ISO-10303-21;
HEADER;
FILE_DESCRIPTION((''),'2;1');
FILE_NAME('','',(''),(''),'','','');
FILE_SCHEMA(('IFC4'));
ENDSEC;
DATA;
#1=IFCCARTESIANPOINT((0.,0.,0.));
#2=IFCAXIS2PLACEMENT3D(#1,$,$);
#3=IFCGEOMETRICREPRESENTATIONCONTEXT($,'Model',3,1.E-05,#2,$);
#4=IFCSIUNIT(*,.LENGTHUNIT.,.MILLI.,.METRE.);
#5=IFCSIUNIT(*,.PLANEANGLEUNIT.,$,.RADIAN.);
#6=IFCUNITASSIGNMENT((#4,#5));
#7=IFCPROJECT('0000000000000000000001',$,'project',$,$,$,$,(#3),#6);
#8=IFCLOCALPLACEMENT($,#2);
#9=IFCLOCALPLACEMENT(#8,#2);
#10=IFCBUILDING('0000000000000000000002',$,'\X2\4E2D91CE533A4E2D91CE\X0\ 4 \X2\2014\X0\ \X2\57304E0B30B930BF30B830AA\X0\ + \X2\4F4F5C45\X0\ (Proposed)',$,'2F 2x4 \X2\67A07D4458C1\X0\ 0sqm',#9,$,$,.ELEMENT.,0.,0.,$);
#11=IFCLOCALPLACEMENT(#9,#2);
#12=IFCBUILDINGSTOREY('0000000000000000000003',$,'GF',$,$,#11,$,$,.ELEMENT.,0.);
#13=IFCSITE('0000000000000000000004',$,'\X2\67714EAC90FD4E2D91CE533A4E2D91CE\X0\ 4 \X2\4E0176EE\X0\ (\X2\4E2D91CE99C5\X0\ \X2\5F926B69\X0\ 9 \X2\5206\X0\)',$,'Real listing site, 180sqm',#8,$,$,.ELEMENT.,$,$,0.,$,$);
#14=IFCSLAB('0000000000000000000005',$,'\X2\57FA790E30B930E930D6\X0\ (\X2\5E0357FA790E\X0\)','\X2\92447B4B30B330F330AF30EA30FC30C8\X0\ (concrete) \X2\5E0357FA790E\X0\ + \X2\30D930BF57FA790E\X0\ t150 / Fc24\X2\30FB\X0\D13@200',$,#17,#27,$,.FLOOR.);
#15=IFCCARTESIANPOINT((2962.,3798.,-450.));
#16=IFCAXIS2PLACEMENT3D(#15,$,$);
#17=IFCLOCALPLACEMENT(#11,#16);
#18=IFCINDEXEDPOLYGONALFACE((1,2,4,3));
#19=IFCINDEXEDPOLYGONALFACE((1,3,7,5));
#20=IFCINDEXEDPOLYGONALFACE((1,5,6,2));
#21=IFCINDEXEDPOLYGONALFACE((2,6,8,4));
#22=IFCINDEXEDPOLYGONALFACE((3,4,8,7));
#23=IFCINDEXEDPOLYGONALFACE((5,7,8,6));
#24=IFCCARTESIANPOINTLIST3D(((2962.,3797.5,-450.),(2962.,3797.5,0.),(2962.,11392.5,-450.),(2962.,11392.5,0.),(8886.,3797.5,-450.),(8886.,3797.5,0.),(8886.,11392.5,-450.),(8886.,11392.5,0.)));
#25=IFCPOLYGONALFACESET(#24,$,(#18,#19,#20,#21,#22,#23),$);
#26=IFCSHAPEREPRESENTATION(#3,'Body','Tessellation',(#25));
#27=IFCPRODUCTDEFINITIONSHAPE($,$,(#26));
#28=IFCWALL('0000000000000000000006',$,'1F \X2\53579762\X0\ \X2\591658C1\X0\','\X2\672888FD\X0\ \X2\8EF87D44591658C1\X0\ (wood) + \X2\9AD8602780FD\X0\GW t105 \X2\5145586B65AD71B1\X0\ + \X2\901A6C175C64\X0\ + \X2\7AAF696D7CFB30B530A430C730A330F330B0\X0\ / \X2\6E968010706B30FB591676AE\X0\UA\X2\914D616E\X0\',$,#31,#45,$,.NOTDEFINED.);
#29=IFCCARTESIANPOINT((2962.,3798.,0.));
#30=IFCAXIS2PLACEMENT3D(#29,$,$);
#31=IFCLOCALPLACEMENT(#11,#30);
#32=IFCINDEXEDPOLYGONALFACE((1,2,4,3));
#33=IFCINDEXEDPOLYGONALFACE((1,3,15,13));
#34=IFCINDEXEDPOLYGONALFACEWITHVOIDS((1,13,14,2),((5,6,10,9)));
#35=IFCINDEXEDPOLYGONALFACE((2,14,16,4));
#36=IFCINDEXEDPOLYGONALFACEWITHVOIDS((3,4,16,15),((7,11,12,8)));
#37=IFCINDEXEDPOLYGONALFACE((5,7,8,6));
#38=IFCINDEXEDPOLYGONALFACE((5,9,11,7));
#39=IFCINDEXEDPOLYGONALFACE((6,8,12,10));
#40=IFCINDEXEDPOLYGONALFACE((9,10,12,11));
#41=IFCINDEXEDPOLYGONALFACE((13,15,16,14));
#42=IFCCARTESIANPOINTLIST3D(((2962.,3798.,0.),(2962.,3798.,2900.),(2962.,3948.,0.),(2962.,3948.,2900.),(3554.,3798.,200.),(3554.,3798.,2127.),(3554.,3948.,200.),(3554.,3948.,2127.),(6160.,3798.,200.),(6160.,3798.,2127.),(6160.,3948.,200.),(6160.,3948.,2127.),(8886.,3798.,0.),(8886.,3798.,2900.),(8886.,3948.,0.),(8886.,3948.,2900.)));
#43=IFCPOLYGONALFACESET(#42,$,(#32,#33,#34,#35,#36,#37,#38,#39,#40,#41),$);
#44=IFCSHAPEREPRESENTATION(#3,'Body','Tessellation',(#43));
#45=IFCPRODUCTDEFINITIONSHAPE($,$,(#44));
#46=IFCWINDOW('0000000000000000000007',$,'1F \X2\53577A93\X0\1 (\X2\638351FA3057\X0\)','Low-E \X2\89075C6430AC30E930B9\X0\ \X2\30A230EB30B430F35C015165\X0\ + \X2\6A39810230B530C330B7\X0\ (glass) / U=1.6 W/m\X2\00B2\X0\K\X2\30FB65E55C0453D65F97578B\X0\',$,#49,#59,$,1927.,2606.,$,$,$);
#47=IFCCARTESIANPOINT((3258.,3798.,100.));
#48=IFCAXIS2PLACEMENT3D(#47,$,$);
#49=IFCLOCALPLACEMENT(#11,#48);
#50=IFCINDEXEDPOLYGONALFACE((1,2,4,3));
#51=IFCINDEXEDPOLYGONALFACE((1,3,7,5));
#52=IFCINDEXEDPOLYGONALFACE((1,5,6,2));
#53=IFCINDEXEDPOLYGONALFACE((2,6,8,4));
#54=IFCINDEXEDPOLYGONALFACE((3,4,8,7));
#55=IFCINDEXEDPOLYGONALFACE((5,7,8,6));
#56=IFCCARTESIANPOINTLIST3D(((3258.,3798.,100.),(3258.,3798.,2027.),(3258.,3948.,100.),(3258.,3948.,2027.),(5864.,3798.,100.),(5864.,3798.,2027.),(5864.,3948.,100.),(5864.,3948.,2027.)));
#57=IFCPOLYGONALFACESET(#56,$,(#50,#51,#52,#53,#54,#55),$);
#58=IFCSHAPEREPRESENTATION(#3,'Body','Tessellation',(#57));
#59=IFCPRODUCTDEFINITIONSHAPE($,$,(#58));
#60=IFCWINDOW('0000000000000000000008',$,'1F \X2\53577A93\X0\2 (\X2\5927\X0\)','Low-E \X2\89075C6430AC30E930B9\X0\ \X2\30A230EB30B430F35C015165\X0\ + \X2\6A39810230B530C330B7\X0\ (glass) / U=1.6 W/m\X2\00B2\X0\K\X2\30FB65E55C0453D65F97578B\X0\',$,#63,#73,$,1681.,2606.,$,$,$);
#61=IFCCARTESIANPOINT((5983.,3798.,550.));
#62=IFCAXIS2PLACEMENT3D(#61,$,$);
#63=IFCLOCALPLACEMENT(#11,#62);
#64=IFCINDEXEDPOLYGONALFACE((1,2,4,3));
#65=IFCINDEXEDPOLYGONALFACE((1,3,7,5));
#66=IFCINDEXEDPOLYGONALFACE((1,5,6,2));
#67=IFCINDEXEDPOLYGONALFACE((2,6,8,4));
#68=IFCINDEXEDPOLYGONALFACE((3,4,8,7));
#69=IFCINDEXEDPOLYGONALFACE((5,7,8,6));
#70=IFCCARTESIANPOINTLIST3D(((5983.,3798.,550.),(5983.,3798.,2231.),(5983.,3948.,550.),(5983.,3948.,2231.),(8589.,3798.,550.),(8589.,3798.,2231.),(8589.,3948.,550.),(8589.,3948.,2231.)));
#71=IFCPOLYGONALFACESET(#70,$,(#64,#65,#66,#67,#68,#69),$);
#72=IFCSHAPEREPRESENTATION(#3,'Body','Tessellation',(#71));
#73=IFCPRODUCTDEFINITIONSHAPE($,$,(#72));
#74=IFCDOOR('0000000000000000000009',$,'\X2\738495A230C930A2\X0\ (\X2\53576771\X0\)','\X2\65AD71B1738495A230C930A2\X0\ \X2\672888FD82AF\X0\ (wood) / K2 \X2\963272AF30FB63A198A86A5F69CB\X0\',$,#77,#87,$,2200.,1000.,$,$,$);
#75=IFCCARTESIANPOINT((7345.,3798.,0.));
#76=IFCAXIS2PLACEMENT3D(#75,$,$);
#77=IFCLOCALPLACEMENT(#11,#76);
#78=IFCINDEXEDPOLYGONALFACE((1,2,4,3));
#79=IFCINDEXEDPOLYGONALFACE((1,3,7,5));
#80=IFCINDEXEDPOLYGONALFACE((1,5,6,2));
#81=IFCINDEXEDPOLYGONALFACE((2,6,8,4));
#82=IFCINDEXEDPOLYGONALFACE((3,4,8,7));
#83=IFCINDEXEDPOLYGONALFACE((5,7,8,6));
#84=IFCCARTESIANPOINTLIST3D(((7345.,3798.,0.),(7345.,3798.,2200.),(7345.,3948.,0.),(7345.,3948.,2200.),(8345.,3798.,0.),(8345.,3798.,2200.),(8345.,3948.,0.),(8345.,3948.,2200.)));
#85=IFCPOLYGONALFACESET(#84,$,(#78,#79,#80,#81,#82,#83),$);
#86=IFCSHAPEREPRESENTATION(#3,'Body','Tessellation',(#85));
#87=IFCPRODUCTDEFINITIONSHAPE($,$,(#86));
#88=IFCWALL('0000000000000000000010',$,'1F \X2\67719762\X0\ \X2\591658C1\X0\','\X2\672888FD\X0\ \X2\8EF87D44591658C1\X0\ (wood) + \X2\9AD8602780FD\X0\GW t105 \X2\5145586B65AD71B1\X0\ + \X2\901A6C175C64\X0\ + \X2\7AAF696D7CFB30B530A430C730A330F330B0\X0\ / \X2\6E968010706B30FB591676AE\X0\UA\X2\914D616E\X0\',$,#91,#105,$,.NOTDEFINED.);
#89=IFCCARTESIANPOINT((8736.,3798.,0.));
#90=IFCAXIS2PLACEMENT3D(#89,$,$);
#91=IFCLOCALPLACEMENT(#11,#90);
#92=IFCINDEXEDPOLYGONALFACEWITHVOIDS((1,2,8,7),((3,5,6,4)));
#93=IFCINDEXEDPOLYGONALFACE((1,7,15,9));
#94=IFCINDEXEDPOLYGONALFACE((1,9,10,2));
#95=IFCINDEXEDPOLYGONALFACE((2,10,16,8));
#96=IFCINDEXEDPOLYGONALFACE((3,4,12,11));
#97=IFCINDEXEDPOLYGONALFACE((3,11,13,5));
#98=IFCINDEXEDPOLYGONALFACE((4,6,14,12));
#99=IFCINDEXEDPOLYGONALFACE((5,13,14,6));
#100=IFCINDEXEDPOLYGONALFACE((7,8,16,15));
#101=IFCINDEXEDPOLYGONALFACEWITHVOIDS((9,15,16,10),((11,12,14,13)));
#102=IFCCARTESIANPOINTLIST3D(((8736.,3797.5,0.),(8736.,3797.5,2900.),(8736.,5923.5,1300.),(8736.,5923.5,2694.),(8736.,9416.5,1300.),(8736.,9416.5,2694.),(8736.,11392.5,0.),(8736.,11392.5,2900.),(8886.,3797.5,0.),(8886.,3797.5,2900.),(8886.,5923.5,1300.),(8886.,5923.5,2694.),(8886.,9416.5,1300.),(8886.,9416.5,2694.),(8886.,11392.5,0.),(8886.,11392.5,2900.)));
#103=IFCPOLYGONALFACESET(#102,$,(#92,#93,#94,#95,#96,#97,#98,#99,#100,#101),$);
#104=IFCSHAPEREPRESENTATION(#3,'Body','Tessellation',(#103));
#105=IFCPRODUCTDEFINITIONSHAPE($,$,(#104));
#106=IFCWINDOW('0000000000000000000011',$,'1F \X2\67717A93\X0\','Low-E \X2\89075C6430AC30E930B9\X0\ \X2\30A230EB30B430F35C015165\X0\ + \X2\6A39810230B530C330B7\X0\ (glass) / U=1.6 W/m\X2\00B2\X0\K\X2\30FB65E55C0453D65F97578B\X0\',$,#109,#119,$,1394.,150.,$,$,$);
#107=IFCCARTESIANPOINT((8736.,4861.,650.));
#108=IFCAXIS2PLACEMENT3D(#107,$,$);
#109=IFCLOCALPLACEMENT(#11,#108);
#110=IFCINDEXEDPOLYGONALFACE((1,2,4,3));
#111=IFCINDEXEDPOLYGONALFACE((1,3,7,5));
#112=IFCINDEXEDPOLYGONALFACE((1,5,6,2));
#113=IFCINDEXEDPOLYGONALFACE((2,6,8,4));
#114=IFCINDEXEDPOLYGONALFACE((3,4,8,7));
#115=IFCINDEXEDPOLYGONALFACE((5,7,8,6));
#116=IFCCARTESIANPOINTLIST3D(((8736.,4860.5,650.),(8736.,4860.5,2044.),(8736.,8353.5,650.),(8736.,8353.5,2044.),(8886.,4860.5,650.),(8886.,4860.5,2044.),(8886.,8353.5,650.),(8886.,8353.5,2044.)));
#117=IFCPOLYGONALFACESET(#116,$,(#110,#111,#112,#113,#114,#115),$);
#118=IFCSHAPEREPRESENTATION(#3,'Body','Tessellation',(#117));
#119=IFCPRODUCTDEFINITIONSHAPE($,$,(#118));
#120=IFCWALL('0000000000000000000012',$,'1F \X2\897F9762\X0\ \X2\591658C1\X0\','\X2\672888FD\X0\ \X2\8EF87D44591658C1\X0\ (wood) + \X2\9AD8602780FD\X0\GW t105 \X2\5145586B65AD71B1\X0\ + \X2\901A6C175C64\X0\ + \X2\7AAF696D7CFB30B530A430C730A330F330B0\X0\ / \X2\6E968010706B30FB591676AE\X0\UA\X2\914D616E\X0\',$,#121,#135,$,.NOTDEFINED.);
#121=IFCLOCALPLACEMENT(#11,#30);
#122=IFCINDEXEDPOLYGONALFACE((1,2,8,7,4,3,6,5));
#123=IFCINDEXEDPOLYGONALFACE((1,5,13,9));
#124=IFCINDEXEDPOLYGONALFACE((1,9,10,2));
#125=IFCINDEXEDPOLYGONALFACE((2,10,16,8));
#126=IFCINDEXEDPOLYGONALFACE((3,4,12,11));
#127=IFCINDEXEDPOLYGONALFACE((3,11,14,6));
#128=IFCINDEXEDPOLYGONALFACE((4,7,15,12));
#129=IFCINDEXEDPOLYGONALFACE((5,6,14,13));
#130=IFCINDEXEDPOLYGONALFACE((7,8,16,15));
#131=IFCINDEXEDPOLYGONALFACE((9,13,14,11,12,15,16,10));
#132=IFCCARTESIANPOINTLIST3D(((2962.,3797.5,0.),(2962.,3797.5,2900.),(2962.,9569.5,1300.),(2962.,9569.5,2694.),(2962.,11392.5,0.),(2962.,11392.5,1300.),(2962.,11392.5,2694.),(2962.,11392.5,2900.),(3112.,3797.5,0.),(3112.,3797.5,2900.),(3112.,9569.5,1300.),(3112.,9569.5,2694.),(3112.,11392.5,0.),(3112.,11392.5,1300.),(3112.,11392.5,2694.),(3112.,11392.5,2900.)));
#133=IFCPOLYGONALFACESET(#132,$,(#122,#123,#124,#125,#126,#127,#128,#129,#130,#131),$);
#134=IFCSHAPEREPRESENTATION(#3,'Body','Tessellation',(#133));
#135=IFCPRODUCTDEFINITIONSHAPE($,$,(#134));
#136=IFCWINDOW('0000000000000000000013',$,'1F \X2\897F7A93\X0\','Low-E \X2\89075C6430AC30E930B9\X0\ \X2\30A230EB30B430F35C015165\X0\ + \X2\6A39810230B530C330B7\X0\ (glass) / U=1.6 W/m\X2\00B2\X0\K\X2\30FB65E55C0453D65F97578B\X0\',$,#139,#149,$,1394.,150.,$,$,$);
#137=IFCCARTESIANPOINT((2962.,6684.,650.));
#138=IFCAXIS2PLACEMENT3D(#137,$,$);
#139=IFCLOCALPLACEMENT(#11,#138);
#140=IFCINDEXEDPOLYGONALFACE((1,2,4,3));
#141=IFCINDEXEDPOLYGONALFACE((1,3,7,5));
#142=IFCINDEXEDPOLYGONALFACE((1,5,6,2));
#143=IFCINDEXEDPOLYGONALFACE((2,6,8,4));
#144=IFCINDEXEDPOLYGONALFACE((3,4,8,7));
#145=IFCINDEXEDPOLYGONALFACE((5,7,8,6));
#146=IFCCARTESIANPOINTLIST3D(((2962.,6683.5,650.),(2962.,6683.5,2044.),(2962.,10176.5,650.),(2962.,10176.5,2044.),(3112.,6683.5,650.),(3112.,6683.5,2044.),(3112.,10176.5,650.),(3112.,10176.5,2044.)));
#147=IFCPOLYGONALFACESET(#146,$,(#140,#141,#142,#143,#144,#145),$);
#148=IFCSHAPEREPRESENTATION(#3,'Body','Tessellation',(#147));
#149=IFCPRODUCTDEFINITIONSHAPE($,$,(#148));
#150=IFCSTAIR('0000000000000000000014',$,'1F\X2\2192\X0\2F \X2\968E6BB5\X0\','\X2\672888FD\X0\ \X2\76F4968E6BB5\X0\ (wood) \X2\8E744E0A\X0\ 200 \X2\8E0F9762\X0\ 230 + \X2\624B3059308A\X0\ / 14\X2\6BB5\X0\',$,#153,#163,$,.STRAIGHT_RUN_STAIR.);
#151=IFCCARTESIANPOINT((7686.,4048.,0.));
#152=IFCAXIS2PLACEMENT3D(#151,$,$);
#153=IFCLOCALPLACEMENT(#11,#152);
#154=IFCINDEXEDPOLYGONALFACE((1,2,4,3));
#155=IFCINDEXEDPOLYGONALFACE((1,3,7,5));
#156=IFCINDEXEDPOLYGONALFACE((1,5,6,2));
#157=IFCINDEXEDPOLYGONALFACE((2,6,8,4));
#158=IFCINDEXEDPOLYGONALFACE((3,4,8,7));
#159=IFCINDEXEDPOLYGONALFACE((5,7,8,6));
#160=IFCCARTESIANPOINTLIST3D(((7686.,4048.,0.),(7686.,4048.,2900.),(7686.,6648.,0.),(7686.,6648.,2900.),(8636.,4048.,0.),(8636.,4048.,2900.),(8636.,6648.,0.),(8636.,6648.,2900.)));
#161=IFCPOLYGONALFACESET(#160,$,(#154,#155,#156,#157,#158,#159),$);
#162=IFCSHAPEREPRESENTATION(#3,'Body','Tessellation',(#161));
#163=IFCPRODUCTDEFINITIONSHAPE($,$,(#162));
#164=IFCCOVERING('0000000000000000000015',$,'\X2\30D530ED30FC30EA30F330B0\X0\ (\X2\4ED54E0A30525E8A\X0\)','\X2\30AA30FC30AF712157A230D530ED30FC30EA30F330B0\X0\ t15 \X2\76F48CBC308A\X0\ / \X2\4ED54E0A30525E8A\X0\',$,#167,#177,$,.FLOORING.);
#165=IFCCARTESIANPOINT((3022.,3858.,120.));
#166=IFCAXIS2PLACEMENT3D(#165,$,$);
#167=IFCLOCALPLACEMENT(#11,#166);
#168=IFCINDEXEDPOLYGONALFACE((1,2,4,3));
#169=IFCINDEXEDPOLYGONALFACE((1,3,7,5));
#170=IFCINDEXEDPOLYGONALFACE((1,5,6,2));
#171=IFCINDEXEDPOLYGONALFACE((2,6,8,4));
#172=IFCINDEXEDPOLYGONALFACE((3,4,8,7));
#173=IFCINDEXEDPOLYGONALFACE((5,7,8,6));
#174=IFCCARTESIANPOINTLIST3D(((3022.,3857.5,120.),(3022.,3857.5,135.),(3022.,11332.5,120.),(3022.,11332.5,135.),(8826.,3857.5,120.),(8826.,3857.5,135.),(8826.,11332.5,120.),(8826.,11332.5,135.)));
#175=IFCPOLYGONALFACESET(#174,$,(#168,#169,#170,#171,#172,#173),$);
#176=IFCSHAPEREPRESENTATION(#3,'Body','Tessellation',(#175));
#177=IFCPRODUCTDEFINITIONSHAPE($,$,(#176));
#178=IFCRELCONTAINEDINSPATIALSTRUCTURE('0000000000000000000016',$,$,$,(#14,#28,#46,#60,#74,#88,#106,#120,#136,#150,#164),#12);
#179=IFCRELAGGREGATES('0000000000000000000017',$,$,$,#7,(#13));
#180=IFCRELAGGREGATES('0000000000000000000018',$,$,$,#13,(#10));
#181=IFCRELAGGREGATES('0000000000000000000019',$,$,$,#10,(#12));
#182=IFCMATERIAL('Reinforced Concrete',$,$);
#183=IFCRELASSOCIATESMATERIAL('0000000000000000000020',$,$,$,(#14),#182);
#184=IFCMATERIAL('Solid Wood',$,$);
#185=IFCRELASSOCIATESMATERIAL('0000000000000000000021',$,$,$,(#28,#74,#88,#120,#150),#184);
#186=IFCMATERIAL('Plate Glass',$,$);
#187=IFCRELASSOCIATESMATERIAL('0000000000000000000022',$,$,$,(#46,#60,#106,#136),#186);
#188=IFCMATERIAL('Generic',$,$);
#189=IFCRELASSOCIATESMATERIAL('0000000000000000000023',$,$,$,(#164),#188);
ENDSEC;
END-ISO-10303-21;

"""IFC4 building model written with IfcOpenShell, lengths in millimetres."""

from ifc_helpers import new_model, si_unit, frame, frame_2d, origin, place, context, project, spatial, rectangle, extrude, material, element, fill, save


model = new_model("IFC4")

# Units and contexts
model_context = context("Model", 3, precision=1e-05, world=origin())
ifc_project = project(units=[si_unit("LENGTHUNIT", "METRE", prefix="MILLI"), si_unit("PLANEANGLEUNIT", "RADIAN")], contexts=[model_context])

# Site, building, storey
site_placement = place(None, origin())
site = spatial("IfcSite", under=ifc_project, at=site_placement, Name="東京都中野区中野 4 丁目 (中野駅 徒歩 9 分)", ObjectType="Real listing site, 180sqm", CompositionType="ELEMENT", RefElevation=0.0)
building_placement = place(site_placement, origin())
building = spatial("IfcBuilding", under=site, at=building_placement, Name="中野区中野 4 — 地下スタジオ + 住居 (Proposed)", ObjectType="2F 2x4 枠組壁 0sqm", CompositionType="ELEMENT", ElevationOfRefHeight=0.0, ElevationOfTerrain=0.0)
storey_placement = place(building_placement, origin())
storey = spatial("IfcBuildingStorey", under=building, at=storey_placement, Name="GF", CompositionType="ELEMENT", Elevation=0.0)

# Slab
ifc_material_1 = material(Name="Reinforced Concrete")
slab_1_placement = place(storey_placement, frame((2962.0, 3798.0, -450.0)))
element("IfcSlab", 1, at=slab_1_placement, inside=storey, material=ifc_material_1, Name="基礎スラブ (布基礎)", Description="鉄筋コンクリート (concrete) 布基礎 + ベタ基礎 t150 / Fc24・D13@200", PredefinedType="FLOOR", context=model_context, shape_type="SweptSolid", body=[
    extrude(rectangle(XDim=5924.0, YDim=7595.0, at=frame_2d((2962.0, 3797.0))), frame((2962.0, 3798.0, -450.0)), (0.0, 0.0, 1.0), 450.0),
])
ifc_material_2 = material(Name="Solid Wood")

# Wall, openings, windows, door
wall_1_placement = place(storey_placement, frame((2962.0, 3798.0, 0.0)))
wall_1 = element("IfcWall", 2, at=wall_1_placement, inside=storey, material=ifc_material_2, Name="1F 南面 外壁", Description="木製 軸組外壁 (wood) + 高性能GW t105 充填断熱 + 通気層 + 窯業系サイディング / 準耐火・外皮UA配慮", PredefinedType="NOTDEFINED", context=model_context, shape_type="SweptSolid", body=[
    extrude(rectangle(XDim=5924.0, YDim=150.0, at=frame_2d((2962.0, 75.0))), frame((2962.0, 3798.0, 0.0)), (0.0, 0.0, 1.0), 2900.0),
])
opening_1_placement = place(storey_placement, frame((3258.0, 3798.0, 100.0)))
opening_1 = element("IfcOpeningElement", 3, at=opening_1_placement, cuts=wall_1, PredefinedType="NOTDEFINED", context=model_context, shape_type="SweptSolid", body=[
    extrude(rectangle(XDim=2606.0, YDim=150.0, at=frame_2d((1303.0, 75.0))), frame((3258.0, 3798.0, 100.0)), (0.0, 0.0, 1.0), 1927.0),
])
opening_2_placement = place(storey_placement, frame((5983.0, 3798.0, 550.0)))
opening_2 = element("IfcOpeningElement", 4, at=opening_2_placement, cuts=wall_1, PredefinedType="NOTDEFINED", context=model_context, shape_type="SweptSolid", body=[
    extrude(rectangle(XDim=2606.0, YDim=150.0, at=frame_2d((1303.0, 75.0))), frame((5983.0, 3798.0, 550.0)), (0.0, 0.0, 1.0), 1681.0),
])
opening_3_placement = place(storey_placement, frame((7345.0, 3798.0, 0.0)))
opening_3 = element("IfcOpeningElement", 5, at=opening_3_placement, cuts=wall_1, PredefinedType="NOTDEFINED", context=model_context, shape_type="SweptSolid", body=[
    extrude(rectangle(XDim=1000.0, YDim=150.0, at=frame_2d((500.0, 75.0))), frame((7345.0, 3798.0, 0.0)), (0.0, 0.0, 1.0), 2200.0),
])
ifc_material_3 = material(Name="Plate Glass")
window_1_placement = place(storey_placement, frame((3258.0, 3798.0, 100.0)))
window_1 = element("IfcWindow", 6, at=window_1_placement, inside=storey, material=ifc_material_3, Name="1F 南窓1 (掃出し)", Description="Low-E 複層ガラス アルゴン封入 + 樹脂サッシ (glass) / U=1.6 W/m²K・日射取得型", OverallHeight=1927.0, OverallWidth=2606.0, context=model_context, shape_type="SweptSolid", body=[
    extrude(rectangle(XDim=2606.0, YDim=150.0, at=frame_2d((1303.0, 75.0))), frame((3258.0, 3798.0, 100.0)), (0.0, 0.0, 1.0), 1927.0),
])
fill(opening_1, window_1)
window_2_placement = place(storey_placement, frame((5983.0, 3798.0, 550.0)))
window_2 = element("IfcWindow", 7, at=window_2_placement, inside=storey, material=ifc_material_3, Name="1F 南窓2 (大)", Description="Low-E 複層ガラス アルゴン封入 + 樹脂サッシ (glass) / U=1.6 W/m²K・日射取得型", OverallHeight=1681.0, OverallWidth=2606.0, context=model_context, shape_type="SweptSolid", body=[
    extrude(rectangle(XDim=2606.0, YDim=150.0, at=frame_2d((1303.0, 75.0))), frame((5983.0, 3798.0, 550.0)), (0.0, 0.0, 1.0), 1681.0),
])
fill(opening_2, window_2)
door_placement = place(storey_placement, frame((7345.0, 3798.0, 0.0)))
door = element("IfcDoor", 8, at=door_placement, inside=storey, material=ifc_material_2, Name="玄関ドア (南東)", Description="断熱玄関ドア 木製芯 (wood) / K2 防犯・採風機構", OverallHeight=2200.0, OverallWidth=1000.0, context=model_context, shape_type="SweptSolid", body=[
    extrude(rectangle(XDim=1000.0, YDim=150.0, at=frame_2d((500.0, 75.0))), frame((7345.0, 3798.0, 0.0)), (0.0, 0.0, 1.0), 2200.0),
])
fill(opening_3, door)

# Walls, openings, windows
wall_2_placement = place(storey_placement, frame((8736.0, 3798.0, 0.0)))
wall_2 = element("IfcWall", 9, at=wall_2_placement, inside=storey, material=ifc_material_2, Name="1F 東面 外壁", Description="木製 軸組外壁 (wood) + 高性能GW t105 充填断熱 + 通気層 + 窯業系サイディング / 準耐火・外皮UA配慮", PredefinedType="NOTDEFINED", context=model_context, shape_type="SweptSolid", body=[
    extrude(rectangle(XDim=150.0, YDim=7595.0, at=frame_2d((75.0, 3797.0))), frame((8736.0, 3798.0, 0.0)), (0.0, 0.0, 1.0), 2900.0),
])
opening_4_placement = place(storey_placement, frame((8736.0, 4861.0, 650.0)))
opening_4 = element("IfcOpeningElement", 10, at=opening_4_placement, cuts=wall_2, PredefinedType="NOTDEFINED", context=model_context, shape_type="SweptSolid", body=[
    extrude(rectangle(XDim=150.0, YDim=3493.0, at=frame_2d((75.0, 1746.0))), frame((8736.0, 4861.0, 650.0)), (0.0, 0.0, 1.0), 1394.0),
])
window_3_placement = place(storey_placement, frame((8736.0, 4861.0, 650.0)))
window_3 = element("IfcWindow", 11, at=window_3_placement, inside=storey, material=ifc_material_3, Name="1F 東窓", Description="Low-E 複層ガラス アルゴン封入 + 樹脂サッシ (glass) / U=1.6 W/m²K・日射取得型", OverallHeight=1394.0, OverallWidth=150.0, context=model_context, shape_type="SweptSolid", body=[
    extrude(rectangle(XDim=150.0, YDim=3493.0, at=frame_2d((75.0, 1746.0))), frame((8736.0, 4861.0, 650.0)), (0.0, 0.0, 1.0), 1394.0),
])
fill(opening_4, window_3)
wall_3_placement = place(storey_placement, frame((2962.0, 3798.0, 0.0)))
wall_3 = element("IfcWall", 12, at=wall_3_placement, inside=storey, material=ifc_material_2, Name="1F 西面 外壁", Description="木製 軸組外壁 (wood) + 高性能GW t105 充填断熱 + 通気層 + 窯業系サイディング / 準耐火・外皮UA配慮", PredefinedType="NOTDEFINED", context=model_context, shape_type="SweptSolid", body=[
    extrude(rectangle(XDim=150.0, YDim=7595.0, at=frame_2d((75.0, 3797.0))), frame((2962.0, 3798.0, 0.0)), (0.0, 0.0, 1.0), 2900.0),
])
opening_5_placement = place(storey_placement, frame((2962.0, 6684.0, 650.0)))
opening_5 = element("IfcOpeningElement", 13, at=opening_5_placement, cuts=wall_3, PredefinedType="NOTDEFINED", context=model_context, shape_type="SweptSolid", body=[
    extrude(rectangle(XDim=150.0, YDim=3493.0, at=frame_2d((75.0, 1746.0))), frame((2962.0, 6684.0, 650.0)), (0.0, 0.0, 1.0), 1394.0),
])
window_4_placement = place(storey_placement, frame((2962.0, 6684.0, 650.0)))
window_4 = element("IfcWindow", 14, at=window_4_placement, inside=storey, material=ifc_material_3, Name="1F 西窓", Description="Low-E 複層ガラス アルゴン封入 + 樹脂サッシ (glass) / U=1.6 W/m²K・日射取得型", OverallHeight=1394.0, OverallWidth=150.0, context=model_context, shape_type="SweptSolid", body=[
    extrude(rectangle(XDim=150.0, YDim=3493.0, at=frame_2d((75.0, 1746.0))), frame((2962.0, 6684.0, 650.0)), (0.0, 0.0, 1.0), 1394.0),
])
fill(opening_5, window_4)

# Stair
stair_placement = place(storey_placement, frame((7686.0, 4048.0, 0.0)))
element("IfcStair", 15, at=stair_placement, inside=storey, material=ifc_material_2, Name="1F→2F 階段", Description="木製 直階段 (wood) 蹴上 200 踏面 230 + 手すり / 14段", PredefinedType="STRAIGHT_RUN_STAIR", context=model_context, shape_type="SweptSolid", body=[
    extrude(rectangle(XDim=950.0, YDim=2600.0, at=frame_2d((475.0, 1300.0))), frame((7686.0, 4048.0, 0.0)), (0.0, 0.0, 1.0), 2900.0),
])

# Covering
ifc_material_4 = material(Name="Generic")
covering_placement = place(storey_placement, frame((3022.0, 3858.0, 120.0)))
element("IfcCovering", 16, at=covering_placement, inside=storey, material=ifc_material_4, Name="フローリング (仕上げ床)", Description="オーク無垢フローリング t15 直貼り / 仕上げ床", PredefinedType="FLOORING", context=model_context, shape_type="SweptSolid", body=[
    extrude(rectangle(XDim=5804.0, YDim=7475.0, at=frame_2d((2902.0, 3737.0))), frame((3022.0, 3858.0, 120.0)), (0.0, 0.0, 1.0), 15.0),
])

save(model, "model.ifc")
